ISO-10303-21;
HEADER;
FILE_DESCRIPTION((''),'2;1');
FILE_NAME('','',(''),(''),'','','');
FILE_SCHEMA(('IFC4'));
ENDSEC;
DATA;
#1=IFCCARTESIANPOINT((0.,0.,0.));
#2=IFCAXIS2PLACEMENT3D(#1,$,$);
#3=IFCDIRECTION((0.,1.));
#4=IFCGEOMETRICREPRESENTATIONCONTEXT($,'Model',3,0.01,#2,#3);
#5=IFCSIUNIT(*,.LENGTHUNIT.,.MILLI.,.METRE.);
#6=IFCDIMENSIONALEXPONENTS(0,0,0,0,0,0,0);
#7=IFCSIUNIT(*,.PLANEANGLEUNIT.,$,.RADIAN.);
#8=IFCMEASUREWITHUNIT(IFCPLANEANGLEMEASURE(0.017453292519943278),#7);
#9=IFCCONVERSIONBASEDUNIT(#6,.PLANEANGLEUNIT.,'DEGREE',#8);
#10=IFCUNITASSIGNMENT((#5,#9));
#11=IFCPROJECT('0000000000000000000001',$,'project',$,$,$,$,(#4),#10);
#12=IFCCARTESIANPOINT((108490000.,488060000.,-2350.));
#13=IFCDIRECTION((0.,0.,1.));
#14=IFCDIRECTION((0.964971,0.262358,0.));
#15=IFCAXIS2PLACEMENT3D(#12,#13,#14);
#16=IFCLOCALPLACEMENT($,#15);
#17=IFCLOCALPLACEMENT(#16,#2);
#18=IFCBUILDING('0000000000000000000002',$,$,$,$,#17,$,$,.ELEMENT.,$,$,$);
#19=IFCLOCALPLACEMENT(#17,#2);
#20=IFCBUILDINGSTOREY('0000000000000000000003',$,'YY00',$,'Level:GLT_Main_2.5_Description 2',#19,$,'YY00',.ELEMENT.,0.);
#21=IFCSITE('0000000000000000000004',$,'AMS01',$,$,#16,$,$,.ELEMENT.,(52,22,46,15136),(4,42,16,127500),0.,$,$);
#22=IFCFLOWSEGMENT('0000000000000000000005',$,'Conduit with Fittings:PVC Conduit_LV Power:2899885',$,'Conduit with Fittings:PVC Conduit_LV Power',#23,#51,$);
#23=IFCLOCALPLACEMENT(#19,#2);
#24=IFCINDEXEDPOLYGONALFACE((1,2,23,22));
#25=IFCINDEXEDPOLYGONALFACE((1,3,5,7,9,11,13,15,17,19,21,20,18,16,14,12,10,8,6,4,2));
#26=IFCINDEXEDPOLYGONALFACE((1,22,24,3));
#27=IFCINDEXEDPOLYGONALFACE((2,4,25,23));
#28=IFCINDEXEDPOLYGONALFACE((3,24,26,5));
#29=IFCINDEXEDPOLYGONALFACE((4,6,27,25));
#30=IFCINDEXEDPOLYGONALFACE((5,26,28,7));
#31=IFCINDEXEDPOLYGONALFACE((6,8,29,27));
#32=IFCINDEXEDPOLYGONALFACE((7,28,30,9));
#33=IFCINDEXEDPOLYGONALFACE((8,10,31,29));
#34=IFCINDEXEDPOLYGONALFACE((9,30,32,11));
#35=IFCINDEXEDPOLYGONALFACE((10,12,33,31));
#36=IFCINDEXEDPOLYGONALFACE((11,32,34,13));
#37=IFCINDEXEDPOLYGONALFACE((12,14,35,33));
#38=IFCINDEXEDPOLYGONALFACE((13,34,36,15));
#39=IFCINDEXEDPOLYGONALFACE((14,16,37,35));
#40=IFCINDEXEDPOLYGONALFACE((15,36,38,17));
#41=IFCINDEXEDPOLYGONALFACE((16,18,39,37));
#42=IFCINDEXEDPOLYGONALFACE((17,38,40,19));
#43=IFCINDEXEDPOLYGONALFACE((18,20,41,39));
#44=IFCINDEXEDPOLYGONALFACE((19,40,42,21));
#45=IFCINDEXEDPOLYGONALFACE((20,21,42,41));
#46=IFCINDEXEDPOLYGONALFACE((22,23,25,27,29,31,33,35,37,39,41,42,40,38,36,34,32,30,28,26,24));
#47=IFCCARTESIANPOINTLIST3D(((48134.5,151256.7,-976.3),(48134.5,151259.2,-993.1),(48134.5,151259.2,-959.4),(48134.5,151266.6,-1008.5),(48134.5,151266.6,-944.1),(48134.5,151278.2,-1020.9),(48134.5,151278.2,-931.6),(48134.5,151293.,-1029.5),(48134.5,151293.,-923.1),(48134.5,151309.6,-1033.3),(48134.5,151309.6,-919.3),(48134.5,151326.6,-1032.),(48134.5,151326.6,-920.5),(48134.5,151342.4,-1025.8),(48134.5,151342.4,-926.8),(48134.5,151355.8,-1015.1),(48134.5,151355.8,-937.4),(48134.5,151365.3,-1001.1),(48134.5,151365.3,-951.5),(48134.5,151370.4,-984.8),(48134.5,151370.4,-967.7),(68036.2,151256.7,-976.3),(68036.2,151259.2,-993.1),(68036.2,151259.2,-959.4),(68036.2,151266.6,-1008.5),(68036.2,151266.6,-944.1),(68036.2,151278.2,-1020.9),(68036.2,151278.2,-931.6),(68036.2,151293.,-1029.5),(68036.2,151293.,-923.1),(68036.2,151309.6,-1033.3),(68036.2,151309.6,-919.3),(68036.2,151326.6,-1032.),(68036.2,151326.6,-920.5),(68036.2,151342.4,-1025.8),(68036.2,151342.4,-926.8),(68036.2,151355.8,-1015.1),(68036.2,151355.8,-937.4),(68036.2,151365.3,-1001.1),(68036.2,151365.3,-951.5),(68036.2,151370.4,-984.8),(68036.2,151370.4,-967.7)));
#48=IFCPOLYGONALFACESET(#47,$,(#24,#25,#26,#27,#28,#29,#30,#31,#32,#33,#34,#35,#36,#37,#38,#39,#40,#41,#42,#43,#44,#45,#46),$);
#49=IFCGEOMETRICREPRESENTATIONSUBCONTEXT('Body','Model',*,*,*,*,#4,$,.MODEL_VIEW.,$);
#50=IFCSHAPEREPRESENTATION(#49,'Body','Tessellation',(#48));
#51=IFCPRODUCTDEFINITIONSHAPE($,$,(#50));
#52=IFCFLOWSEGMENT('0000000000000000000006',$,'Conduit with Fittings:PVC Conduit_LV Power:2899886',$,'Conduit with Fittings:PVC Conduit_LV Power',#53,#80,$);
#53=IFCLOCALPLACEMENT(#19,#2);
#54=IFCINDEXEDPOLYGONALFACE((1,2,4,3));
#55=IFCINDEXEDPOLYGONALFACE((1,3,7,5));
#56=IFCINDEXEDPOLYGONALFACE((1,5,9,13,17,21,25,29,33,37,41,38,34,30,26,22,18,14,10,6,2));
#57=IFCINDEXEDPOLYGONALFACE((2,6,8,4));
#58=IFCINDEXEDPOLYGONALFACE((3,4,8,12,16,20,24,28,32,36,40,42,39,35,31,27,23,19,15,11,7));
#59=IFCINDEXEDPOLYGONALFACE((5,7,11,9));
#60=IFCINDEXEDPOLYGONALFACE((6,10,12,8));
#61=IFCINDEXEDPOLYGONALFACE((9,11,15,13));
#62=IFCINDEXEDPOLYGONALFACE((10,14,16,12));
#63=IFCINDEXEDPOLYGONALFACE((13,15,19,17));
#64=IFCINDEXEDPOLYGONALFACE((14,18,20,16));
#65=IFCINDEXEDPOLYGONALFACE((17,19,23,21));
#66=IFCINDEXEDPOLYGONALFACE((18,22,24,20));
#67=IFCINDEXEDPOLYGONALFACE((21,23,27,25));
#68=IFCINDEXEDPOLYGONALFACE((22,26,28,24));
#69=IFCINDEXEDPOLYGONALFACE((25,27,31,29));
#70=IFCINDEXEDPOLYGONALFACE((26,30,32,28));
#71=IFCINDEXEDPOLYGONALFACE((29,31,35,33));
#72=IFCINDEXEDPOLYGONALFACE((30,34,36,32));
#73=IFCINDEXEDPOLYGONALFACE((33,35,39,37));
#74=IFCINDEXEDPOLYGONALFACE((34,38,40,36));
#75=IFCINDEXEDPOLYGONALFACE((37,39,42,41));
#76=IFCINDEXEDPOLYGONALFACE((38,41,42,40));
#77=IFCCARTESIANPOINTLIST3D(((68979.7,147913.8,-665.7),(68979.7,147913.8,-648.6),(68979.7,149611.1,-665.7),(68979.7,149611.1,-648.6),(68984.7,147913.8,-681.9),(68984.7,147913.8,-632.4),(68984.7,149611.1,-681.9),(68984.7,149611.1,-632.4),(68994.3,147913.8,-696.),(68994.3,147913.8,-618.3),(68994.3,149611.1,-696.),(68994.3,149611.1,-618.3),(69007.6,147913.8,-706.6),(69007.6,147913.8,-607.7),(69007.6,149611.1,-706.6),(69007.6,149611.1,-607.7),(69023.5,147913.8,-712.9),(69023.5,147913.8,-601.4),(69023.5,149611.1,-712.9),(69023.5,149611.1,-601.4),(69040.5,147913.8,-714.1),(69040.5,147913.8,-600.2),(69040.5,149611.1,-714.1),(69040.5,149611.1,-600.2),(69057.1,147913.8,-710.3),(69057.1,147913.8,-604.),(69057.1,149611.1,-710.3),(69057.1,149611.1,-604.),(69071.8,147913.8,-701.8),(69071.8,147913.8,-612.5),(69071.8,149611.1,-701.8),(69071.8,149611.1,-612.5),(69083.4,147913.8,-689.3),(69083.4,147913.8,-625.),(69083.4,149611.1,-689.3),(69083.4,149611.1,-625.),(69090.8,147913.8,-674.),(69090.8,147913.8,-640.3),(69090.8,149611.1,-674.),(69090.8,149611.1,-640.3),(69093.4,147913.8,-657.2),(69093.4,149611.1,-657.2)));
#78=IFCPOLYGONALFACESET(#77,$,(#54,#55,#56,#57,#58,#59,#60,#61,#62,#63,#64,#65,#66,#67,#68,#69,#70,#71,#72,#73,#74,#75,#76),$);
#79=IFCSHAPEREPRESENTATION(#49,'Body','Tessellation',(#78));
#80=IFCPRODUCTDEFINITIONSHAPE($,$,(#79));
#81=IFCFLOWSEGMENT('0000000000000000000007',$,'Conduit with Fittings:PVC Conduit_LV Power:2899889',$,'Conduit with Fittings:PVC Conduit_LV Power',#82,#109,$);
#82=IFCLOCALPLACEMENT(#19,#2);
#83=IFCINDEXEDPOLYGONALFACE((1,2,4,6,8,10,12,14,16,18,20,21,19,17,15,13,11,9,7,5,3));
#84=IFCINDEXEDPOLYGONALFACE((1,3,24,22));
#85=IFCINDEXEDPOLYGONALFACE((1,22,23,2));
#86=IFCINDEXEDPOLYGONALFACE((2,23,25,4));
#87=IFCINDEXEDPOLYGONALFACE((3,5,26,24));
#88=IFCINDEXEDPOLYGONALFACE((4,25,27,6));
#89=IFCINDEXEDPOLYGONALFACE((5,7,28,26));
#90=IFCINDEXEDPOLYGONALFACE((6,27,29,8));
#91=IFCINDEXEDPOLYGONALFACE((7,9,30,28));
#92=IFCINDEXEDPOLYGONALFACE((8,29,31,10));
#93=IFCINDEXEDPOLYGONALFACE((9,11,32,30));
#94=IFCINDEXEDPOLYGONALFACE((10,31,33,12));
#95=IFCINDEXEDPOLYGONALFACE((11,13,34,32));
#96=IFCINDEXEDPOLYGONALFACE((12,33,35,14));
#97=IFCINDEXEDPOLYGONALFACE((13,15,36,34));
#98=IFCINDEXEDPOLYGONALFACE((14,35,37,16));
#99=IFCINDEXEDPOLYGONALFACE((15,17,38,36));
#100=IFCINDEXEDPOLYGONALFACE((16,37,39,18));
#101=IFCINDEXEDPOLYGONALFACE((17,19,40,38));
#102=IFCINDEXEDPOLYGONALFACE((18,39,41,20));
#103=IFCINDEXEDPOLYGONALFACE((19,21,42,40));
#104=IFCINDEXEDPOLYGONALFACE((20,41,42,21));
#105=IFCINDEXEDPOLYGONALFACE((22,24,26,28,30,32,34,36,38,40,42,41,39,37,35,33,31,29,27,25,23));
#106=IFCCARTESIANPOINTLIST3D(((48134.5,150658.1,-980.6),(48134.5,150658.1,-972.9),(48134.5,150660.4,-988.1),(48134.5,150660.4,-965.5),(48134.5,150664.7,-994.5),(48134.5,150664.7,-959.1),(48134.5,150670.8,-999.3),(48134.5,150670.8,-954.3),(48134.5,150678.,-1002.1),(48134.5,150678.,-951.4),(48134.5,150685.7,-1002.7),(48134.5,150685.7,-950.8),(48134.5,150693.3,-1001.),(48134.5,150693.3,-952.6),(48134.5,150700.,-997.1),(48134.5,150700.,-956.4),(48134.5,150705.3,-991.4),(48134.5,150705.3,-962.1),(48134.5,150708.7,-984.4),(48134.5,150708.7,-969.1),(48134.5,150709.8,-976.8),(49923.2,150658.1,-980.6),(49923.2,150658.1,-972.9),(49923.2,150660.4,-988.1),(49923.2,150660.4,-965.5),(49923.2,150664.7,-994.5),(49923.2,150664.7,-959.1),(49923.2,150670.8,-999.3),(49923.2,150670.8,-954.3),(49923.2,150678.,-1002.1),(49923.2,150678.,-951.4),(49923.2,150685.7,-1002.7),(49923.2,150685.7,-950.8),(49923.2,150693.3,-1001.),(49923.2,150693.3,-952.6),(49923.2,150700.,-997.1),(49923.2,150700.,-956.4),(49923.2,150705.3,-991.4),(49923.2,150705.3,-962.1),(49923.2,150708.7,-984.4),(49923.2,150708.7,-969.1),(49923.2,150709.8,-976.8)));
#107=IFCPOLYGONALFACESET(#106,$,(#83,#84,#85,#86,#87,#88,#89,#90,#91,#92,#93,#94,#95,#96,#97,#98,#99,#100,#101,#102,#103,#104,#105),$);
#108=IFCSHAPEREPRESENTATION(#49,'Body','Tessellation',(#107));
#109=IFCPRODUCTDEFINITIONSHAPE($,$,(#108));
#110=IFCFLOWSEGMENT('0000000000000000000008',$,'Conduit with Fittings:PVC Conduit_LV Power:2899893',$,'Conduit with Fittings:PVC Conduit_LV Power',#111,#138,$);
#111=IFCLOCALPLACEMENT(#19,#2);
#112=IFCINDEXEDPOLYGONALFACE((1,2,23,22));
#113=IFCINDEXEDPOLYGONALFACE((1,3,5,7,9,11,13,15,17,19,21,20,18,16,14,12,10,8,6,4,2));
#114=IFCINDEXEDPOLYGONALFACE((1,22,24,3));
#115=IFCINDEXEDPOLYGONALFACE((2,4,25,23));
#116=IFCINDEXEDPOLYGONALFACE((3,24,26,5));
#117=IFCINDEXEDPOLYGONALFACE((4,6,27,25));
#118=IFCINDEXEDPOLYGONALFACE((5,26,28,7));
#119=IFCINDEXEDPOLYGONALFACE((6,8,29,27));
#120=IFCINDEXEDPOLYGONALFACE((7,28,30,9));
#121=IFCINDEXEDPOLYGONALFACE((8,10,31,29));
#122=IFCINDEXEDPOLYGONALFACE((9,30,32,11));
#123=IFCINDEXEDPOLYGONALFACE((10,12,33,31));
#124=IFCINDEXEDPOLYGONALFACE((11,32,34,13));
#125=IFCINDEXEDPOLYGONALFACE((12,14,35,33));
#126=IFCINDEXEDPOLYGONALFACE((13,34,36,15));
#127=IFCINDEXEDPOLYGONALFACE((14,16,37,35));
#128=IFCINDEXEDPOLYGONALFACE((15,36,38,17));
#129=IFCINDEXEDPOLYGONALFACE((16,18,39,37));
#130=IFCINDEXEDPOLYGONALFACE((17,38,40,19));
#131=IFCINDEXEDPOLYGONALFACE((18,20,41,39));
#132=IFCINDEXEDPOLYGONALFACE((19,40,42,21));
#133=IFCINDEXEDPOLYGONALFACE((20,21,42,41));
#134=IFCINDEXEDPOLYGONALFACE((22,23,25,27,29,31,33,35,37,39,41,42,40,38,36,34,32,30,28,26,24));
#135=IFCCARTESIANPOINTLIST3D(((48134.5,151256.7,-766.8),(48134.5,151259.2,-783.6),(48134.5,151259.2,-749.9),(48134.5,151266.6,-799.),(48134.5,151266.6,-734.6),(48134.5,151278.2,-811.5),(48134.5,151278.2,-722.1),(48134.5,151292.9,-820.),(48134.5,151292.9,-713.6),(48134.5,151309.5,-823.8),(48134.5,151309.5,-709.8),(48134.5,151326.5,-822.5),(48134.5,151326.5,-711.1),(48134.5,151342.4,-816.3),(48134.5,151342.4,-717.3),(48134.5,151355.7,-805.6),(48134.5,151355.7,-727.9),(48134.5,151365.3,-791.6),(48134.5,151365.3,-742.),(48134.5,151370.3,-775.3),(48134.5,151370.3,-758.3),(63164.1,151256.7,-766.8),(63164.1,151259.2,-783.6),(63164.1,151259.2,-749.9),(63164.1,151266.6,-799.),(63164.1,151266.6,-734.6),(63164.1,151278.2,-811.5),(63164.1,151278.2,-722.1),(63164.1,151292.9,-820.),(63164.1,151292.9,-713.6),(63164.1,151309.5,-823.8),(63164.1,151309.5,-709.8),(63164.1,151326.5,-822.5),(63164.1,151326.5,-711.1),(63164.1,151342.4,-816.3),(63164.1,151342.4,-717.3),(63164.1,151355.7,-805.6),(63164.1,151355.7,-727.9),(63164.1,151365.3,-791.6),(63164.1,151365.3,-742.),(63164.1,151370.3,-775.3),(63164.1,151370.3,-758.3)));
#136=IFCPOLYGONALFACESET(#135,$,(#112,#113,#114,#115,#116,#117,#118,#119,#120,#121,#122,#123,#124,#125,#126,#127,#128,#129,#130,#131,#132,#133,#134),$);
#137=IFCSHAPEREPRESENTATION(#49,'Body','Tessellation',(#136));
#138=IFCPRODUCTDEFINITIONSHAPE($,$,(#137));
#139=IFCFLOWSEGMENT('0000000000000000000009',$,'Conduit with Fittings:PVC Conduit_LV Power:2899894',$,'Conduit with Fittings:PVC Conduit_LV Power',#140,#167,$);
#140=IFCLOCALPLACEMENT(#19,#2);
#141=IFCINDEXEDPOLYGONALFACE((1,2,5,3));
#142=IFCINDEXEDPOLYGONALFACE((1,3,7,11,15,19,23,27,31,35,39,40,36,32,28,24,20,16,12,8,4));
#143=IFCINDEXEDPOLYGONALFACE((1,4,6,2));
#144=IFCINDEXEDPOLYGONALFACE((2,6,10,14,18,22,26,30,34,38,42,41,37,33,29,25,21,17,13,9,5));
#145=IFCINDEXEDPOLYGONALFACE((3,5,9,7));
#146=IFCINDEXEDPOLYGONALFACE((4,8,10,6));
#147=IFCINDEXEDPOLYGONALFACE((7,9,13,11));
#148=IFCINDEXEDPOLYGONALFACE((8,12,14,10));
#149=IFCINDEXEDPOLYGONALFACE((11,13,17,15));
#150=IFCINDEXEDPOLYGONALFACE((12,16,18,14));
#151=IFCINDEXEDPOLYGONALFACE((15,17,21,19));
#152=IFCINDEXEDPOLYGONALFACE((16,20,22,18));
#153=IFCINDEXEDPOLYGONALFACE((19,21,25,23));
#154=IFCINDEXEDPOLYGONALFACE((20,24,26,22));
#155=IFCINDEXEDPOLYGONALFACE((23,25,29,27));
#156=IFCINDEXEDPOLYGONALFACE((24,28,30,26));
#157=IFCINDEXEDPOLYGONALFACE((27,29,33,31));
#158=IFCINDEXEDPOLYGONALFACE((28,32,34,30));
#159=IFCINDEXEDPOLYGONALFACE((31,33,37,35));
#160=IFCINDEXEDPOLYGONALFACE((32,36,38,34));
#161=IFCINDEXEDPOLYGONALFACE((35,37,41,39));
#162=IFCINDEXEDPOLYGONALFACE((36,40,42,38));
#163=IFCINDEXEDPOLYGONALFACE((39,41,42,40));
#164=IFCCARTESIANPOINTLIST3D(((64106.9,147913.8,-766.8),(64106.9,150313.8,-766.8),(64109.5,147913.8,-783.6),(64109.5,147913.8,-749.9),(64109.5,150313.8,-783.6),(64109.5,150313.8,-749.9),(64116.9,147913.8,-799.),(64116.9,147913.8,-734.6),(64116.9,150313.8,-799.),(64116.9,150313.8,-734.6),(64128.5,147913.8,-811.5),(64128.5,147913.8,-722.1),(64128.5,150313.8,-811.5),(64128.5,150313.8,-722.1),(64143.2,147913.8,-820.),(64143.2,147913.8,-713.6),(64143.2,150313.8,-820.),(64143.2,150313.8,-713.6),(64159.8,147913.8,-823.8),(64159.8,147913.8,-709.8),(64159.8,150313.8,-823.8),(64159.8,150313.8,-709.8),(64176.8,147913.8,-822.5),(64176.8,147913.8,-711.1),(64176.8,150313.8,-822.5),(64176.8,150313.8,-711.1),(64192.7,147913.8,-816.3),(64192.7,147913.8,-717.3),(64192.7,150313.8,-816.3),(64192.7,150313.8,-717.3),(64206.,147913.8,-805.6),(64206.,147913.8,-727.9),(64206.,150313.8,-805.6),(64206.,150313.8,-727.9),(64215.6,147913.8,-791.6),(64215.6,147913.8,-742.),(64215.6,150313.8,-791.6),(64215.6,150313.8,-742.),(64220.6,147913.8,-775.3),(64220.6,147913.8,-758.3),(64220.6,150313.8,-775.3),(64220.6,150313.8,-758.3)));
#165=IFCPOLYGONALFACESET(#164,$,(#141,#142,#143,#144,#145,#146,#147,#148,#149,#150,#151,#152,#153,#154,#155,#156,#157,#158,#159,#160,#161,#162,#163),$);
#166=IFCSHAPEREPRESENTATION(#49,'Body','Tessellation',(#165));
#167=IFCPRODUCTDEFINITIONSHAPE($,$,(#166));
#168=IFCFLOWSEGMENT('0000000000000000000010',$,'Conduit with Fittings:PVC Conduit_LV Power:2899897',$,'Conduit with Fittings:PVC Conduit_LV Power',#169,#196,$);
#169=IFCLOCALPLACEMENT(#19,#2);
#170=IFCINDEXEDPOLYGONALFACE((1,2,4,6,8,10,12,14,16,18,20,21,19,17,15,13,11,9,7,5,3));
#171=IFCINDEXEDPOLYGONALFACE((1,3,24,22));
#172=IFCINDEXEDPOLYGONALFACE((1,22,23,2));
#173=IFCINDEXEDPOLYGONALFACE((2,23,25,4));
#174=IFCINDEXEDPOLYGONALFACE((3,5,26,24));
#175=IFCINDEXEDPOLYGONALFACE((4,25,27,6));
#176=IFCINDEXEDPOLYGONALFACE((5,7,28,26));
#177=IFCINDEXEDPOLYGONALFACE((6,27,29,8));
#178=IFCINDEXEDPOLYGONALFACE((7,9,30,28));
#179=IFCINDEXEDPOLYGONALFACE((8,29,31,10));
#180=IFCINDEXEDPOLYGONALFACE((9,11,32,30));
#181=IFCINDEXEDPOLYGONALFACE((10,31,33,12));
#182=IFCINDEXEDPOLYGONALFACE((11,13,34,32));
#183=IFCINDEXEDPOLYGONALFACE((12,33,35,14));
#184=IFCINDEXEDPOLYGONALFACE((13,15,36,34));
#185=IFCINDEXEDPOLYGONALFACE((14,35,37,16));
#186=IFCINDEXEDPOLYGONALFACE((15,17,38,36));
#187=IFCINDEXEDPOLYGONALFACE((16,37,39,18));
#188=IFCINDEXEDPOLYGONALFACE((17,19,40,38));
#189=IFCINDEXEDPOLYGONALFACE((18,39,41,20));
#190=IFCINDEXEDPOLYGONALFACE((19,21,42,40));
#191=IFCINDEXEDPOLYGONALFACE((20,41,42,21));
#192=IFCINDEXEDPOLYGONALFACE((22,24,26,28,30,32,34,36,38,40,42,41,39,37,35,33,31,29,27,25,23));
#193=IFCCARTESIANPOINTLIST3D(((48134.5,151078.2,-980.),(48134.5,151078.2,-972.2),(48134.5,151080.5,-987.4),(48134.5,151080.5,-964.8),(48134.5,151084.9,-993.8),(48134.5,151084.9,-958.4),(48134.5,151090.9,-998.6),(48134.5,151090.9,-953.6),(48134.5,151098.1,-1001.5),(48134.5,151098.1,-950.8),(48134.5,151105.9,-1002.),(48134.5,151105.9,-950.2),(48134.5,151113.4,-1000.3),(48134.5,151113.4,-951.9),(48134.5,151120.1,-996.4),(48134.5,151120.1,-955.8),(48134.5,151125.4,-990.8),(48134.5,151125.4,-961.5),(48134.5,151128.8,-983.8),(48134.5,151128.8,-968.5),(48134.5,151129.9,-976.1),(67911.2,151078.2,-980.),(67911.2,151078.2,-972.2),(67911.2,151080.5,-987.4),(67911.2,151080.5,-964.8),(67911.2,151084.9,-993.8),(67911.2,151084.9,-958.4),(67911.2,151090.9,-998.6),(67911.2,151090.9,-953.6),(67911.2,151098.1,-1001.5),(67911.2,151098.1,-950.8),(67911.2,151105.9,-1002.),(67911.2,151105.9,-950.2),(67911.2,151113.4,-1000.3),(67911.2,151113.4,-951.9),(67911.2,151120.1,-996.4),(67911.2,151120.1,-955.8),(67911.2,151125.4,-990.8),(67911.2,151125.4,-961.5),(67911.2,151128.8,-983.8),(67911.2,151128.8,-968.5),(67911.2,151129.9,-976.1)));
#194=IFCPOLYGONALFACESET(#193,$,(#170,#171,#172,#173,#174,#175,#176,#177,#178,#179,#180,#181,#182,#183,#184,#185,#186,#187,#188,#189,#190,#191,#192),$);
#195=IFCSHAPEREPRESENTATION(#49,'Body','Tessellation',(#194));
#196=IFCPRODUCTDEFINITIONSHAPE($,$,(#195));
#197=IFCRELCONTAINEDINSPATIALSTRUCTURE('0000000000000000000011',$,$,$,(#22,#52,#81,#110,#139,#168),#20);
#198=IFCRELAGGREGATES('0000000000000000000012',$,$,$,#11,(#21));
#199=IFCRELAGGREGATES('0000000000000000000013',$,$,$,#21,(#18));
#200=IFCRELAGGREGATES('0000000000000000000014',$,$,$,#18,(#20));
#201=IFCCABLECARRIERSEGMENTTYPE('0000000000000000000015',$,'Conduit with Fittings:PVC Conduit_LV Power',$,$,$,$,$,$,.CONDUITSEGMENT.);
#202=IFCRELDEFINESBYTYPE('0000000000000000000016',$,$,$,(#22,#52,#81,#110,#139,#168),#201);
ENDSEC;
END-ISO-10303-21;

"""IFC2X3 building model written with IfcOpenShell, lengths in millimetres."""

from ifc_helpers import new_model, entity, si_unit, converted_unit, direction, frame, frame_2d, origin, origin_2d_with_axis, place, context, subcontext, project, spatial, circle, extrude, type_object, element, save


model = new_model("IFC2X3")

# Units and contexts
model_context = context("Model", 3, precision=0.01, world=origin(), true_north=direction((0.0, 1.0)))
body_context = subcontext(model_context, "Body", "Model", "MODEL_VIEW")
ifc_project = project(units=[si_unit("LENGTHUNIT", "METRE", prefix="MILLI"), converted_unit("PLANEANGLEUNIT", "DEGREE", entity("IfcPlaneAngleMeasure", 0.017453292519943278), si_unit("PLANEANGLEUNIT", "RADIAN"), dimensions=[0, 0, 0, 0, 0, 0, 0])], contexts=[model_context])

# Site, building, storey
site_placement = place(None, frame((108490000.0, 488060000.0, -2350.0), z_axis=(0.0, 0.0, 1.0), x_axis=(0.964971, 0.262358, 0.0)))
site = spatial("IfcSite", under=ifc_project, at=site_placement, Name="AMS01", CompositionType="ELEMENT", RefLatitude=(52, 22, 46, 15136), RefLongitude=(4, 42, 16, 127500), RefElevation=0.0)
building_placement = place(site_placement, origin())
building = spatial("IfcBuilding", under=site, at=building_placement, CompositionType="ELEMENT")
storey_placement = place(building_placement, origin())
storey = spatial("IfcBuildingStorey", under=building, at=storey_placement, Name="YY00", ObjectType="Level:GLT_Main_2.5_Description 2", LongName="YY00", CompositionType="ELEMENT", Elevation=0.0)

# Flow segments
cable_carrier_segment_type = type_object("IfcCableCarrierSegmentType", Name="Conduit with Fittings:PVC Conduit_LV Power", PredefinedType="CONDUITSEGMENT")
flow_segment_1_placement = place(storey_placement, origin())
element("IfcFlowSegment", 1, at=flow_segment_1_placement, inside=storey, type_object=cable_carrier_segment_type, Name="Conduit with Fittings:PVC Conduit_LV Power:2899885", ObjectType="Conduit with Fittings:PVC Conduit_LV Power", context=body_context, shape_type="SweptSolid", body=[
    extrude(circle(Radius=57.2, at=frame_2d((0.0, 0.0), x_axis=(1.0, 0.0))), frame((48134.5, 151313.9, -976.3), z_axis=(1.0, 0.0, 0.0), x_axis=(0.0, -1.0, 0.0)), (0.0, 0.0, 1.0), 19901.7),
])
flow_segment_2_placement = place(storey_placement, origin())
element("IfcFlowSegment", 2, at=flow_segment_2_placement, inside=storey, type_object=cable_carrier_segment_type, Name="Conduit with Fittings:PVC Conduit_LV Power:2899886", ObjectType="Conduit with Fittings:PVC Conduit_LV Power", context=body_context, shape_type="SweptSolid", body=[
    extrude(circle(Radius=57.2, at=origin_2d_with_axis()), frame((69036.2, 147913.8, -657.2), z_axis=(0.0, 1.0, 0.0), x_axis=(1.0, 0.0, 0.0)), (0.0, 0.0, 1.0), 1697.3),
])
flow_segment_3_placement = place(storey_placement, origin())
element("IfcFlowSegment", 3, at=flow_segment_3_placement, inside=storey, type_object=cable_carrier_segment_type, Name="Conduit with Fittings:PVC Conduit_LV Power:2899889", ObjectType="Conduit with Fittings:PVC Conduit_LV Power", context=body_context, shape_type="SweptSolid", body=[
    extrude(circle(Radius=26.0, at=frame_2d((0.0, 0.0), x_axis=(1.0, 0.0))), frame((48134.5, 150683.8, -976.8), z_axis=(1.0, 0.0, 0.0), x_axis=(0.0, 1.0, 0.0)), (0.0, 0.0, 1.0), 1788.7),
])
flow_segment_4_placement = place(storey_placement, origin())
element("IfcFlowSegment", 4, at=flow_segment_4_placement, inside=storey, type_object=cable_carrier_segment_type, Name="Conduit with Fittings:PVC Conduit_LV Power:2899893", ObjectType="Conduit with Fittings:PVC Conduit_LV Power", context=body_context, shape_type="SweptSolid", body=[
    extrude(circle(Radius=57.2, at=origin_2d_with_axis()), frame((48134.5, 151313.8, -766.8), z_axis=(1.0, 0.0, 0.0), x_axis=(0.0, -1.0, 0.0)), (0.0, 0.0, 1.0), 15029.6),
])
flow_segment_5_placement = place(storey_placement, origin())
element("IfcFlowSegment", 5, at=flow_segment_5_placement, inside=storey, type_object=cable_carrier_segment_type, Name="Conduit with Fittings:PVC Conduit_LV Power:2899894", ObjectType="Conduit with Fittings:PVC Conduit_LV Power", context=body_context, shape_type="SweptSolid", body=[
    extrude(circle(Radius=57.2, at=origin_2d_with_axis()), frame((64164.1, 147913.8, -766.8), z_axis=(0.0, 1.0, 0.0), x_axis=(-1.0, 0.0, 0.0)), (0.0, 0.0, 1.0), 2400.0),
])
flow_segment_6_placement = place(storey_placement, origin())
element("IfcFlowSegment", 6, at=flow_segment_6_placement, inside=storey, type_object=cable_carrier_segment_type, Name="Conduit with Fittings:PVC Conduit_LV Power:2899897", ObjectType="Conduit with Fittings:PVC Conduit_LV Power", context=body_context, shape_type="SweptSolid", body=[
    extrude(circle(Radius=26.0, at=origin_2d_with_axis()), frame((48134.5, 151103.9, -976.1), z_axis=(1.0, 0.0, 0.0), x_axis=(0.0, 1.0, 0.0)), (0.0, 0.0, 1.0), 19776.7),
])

save(model, "model.ifc")
